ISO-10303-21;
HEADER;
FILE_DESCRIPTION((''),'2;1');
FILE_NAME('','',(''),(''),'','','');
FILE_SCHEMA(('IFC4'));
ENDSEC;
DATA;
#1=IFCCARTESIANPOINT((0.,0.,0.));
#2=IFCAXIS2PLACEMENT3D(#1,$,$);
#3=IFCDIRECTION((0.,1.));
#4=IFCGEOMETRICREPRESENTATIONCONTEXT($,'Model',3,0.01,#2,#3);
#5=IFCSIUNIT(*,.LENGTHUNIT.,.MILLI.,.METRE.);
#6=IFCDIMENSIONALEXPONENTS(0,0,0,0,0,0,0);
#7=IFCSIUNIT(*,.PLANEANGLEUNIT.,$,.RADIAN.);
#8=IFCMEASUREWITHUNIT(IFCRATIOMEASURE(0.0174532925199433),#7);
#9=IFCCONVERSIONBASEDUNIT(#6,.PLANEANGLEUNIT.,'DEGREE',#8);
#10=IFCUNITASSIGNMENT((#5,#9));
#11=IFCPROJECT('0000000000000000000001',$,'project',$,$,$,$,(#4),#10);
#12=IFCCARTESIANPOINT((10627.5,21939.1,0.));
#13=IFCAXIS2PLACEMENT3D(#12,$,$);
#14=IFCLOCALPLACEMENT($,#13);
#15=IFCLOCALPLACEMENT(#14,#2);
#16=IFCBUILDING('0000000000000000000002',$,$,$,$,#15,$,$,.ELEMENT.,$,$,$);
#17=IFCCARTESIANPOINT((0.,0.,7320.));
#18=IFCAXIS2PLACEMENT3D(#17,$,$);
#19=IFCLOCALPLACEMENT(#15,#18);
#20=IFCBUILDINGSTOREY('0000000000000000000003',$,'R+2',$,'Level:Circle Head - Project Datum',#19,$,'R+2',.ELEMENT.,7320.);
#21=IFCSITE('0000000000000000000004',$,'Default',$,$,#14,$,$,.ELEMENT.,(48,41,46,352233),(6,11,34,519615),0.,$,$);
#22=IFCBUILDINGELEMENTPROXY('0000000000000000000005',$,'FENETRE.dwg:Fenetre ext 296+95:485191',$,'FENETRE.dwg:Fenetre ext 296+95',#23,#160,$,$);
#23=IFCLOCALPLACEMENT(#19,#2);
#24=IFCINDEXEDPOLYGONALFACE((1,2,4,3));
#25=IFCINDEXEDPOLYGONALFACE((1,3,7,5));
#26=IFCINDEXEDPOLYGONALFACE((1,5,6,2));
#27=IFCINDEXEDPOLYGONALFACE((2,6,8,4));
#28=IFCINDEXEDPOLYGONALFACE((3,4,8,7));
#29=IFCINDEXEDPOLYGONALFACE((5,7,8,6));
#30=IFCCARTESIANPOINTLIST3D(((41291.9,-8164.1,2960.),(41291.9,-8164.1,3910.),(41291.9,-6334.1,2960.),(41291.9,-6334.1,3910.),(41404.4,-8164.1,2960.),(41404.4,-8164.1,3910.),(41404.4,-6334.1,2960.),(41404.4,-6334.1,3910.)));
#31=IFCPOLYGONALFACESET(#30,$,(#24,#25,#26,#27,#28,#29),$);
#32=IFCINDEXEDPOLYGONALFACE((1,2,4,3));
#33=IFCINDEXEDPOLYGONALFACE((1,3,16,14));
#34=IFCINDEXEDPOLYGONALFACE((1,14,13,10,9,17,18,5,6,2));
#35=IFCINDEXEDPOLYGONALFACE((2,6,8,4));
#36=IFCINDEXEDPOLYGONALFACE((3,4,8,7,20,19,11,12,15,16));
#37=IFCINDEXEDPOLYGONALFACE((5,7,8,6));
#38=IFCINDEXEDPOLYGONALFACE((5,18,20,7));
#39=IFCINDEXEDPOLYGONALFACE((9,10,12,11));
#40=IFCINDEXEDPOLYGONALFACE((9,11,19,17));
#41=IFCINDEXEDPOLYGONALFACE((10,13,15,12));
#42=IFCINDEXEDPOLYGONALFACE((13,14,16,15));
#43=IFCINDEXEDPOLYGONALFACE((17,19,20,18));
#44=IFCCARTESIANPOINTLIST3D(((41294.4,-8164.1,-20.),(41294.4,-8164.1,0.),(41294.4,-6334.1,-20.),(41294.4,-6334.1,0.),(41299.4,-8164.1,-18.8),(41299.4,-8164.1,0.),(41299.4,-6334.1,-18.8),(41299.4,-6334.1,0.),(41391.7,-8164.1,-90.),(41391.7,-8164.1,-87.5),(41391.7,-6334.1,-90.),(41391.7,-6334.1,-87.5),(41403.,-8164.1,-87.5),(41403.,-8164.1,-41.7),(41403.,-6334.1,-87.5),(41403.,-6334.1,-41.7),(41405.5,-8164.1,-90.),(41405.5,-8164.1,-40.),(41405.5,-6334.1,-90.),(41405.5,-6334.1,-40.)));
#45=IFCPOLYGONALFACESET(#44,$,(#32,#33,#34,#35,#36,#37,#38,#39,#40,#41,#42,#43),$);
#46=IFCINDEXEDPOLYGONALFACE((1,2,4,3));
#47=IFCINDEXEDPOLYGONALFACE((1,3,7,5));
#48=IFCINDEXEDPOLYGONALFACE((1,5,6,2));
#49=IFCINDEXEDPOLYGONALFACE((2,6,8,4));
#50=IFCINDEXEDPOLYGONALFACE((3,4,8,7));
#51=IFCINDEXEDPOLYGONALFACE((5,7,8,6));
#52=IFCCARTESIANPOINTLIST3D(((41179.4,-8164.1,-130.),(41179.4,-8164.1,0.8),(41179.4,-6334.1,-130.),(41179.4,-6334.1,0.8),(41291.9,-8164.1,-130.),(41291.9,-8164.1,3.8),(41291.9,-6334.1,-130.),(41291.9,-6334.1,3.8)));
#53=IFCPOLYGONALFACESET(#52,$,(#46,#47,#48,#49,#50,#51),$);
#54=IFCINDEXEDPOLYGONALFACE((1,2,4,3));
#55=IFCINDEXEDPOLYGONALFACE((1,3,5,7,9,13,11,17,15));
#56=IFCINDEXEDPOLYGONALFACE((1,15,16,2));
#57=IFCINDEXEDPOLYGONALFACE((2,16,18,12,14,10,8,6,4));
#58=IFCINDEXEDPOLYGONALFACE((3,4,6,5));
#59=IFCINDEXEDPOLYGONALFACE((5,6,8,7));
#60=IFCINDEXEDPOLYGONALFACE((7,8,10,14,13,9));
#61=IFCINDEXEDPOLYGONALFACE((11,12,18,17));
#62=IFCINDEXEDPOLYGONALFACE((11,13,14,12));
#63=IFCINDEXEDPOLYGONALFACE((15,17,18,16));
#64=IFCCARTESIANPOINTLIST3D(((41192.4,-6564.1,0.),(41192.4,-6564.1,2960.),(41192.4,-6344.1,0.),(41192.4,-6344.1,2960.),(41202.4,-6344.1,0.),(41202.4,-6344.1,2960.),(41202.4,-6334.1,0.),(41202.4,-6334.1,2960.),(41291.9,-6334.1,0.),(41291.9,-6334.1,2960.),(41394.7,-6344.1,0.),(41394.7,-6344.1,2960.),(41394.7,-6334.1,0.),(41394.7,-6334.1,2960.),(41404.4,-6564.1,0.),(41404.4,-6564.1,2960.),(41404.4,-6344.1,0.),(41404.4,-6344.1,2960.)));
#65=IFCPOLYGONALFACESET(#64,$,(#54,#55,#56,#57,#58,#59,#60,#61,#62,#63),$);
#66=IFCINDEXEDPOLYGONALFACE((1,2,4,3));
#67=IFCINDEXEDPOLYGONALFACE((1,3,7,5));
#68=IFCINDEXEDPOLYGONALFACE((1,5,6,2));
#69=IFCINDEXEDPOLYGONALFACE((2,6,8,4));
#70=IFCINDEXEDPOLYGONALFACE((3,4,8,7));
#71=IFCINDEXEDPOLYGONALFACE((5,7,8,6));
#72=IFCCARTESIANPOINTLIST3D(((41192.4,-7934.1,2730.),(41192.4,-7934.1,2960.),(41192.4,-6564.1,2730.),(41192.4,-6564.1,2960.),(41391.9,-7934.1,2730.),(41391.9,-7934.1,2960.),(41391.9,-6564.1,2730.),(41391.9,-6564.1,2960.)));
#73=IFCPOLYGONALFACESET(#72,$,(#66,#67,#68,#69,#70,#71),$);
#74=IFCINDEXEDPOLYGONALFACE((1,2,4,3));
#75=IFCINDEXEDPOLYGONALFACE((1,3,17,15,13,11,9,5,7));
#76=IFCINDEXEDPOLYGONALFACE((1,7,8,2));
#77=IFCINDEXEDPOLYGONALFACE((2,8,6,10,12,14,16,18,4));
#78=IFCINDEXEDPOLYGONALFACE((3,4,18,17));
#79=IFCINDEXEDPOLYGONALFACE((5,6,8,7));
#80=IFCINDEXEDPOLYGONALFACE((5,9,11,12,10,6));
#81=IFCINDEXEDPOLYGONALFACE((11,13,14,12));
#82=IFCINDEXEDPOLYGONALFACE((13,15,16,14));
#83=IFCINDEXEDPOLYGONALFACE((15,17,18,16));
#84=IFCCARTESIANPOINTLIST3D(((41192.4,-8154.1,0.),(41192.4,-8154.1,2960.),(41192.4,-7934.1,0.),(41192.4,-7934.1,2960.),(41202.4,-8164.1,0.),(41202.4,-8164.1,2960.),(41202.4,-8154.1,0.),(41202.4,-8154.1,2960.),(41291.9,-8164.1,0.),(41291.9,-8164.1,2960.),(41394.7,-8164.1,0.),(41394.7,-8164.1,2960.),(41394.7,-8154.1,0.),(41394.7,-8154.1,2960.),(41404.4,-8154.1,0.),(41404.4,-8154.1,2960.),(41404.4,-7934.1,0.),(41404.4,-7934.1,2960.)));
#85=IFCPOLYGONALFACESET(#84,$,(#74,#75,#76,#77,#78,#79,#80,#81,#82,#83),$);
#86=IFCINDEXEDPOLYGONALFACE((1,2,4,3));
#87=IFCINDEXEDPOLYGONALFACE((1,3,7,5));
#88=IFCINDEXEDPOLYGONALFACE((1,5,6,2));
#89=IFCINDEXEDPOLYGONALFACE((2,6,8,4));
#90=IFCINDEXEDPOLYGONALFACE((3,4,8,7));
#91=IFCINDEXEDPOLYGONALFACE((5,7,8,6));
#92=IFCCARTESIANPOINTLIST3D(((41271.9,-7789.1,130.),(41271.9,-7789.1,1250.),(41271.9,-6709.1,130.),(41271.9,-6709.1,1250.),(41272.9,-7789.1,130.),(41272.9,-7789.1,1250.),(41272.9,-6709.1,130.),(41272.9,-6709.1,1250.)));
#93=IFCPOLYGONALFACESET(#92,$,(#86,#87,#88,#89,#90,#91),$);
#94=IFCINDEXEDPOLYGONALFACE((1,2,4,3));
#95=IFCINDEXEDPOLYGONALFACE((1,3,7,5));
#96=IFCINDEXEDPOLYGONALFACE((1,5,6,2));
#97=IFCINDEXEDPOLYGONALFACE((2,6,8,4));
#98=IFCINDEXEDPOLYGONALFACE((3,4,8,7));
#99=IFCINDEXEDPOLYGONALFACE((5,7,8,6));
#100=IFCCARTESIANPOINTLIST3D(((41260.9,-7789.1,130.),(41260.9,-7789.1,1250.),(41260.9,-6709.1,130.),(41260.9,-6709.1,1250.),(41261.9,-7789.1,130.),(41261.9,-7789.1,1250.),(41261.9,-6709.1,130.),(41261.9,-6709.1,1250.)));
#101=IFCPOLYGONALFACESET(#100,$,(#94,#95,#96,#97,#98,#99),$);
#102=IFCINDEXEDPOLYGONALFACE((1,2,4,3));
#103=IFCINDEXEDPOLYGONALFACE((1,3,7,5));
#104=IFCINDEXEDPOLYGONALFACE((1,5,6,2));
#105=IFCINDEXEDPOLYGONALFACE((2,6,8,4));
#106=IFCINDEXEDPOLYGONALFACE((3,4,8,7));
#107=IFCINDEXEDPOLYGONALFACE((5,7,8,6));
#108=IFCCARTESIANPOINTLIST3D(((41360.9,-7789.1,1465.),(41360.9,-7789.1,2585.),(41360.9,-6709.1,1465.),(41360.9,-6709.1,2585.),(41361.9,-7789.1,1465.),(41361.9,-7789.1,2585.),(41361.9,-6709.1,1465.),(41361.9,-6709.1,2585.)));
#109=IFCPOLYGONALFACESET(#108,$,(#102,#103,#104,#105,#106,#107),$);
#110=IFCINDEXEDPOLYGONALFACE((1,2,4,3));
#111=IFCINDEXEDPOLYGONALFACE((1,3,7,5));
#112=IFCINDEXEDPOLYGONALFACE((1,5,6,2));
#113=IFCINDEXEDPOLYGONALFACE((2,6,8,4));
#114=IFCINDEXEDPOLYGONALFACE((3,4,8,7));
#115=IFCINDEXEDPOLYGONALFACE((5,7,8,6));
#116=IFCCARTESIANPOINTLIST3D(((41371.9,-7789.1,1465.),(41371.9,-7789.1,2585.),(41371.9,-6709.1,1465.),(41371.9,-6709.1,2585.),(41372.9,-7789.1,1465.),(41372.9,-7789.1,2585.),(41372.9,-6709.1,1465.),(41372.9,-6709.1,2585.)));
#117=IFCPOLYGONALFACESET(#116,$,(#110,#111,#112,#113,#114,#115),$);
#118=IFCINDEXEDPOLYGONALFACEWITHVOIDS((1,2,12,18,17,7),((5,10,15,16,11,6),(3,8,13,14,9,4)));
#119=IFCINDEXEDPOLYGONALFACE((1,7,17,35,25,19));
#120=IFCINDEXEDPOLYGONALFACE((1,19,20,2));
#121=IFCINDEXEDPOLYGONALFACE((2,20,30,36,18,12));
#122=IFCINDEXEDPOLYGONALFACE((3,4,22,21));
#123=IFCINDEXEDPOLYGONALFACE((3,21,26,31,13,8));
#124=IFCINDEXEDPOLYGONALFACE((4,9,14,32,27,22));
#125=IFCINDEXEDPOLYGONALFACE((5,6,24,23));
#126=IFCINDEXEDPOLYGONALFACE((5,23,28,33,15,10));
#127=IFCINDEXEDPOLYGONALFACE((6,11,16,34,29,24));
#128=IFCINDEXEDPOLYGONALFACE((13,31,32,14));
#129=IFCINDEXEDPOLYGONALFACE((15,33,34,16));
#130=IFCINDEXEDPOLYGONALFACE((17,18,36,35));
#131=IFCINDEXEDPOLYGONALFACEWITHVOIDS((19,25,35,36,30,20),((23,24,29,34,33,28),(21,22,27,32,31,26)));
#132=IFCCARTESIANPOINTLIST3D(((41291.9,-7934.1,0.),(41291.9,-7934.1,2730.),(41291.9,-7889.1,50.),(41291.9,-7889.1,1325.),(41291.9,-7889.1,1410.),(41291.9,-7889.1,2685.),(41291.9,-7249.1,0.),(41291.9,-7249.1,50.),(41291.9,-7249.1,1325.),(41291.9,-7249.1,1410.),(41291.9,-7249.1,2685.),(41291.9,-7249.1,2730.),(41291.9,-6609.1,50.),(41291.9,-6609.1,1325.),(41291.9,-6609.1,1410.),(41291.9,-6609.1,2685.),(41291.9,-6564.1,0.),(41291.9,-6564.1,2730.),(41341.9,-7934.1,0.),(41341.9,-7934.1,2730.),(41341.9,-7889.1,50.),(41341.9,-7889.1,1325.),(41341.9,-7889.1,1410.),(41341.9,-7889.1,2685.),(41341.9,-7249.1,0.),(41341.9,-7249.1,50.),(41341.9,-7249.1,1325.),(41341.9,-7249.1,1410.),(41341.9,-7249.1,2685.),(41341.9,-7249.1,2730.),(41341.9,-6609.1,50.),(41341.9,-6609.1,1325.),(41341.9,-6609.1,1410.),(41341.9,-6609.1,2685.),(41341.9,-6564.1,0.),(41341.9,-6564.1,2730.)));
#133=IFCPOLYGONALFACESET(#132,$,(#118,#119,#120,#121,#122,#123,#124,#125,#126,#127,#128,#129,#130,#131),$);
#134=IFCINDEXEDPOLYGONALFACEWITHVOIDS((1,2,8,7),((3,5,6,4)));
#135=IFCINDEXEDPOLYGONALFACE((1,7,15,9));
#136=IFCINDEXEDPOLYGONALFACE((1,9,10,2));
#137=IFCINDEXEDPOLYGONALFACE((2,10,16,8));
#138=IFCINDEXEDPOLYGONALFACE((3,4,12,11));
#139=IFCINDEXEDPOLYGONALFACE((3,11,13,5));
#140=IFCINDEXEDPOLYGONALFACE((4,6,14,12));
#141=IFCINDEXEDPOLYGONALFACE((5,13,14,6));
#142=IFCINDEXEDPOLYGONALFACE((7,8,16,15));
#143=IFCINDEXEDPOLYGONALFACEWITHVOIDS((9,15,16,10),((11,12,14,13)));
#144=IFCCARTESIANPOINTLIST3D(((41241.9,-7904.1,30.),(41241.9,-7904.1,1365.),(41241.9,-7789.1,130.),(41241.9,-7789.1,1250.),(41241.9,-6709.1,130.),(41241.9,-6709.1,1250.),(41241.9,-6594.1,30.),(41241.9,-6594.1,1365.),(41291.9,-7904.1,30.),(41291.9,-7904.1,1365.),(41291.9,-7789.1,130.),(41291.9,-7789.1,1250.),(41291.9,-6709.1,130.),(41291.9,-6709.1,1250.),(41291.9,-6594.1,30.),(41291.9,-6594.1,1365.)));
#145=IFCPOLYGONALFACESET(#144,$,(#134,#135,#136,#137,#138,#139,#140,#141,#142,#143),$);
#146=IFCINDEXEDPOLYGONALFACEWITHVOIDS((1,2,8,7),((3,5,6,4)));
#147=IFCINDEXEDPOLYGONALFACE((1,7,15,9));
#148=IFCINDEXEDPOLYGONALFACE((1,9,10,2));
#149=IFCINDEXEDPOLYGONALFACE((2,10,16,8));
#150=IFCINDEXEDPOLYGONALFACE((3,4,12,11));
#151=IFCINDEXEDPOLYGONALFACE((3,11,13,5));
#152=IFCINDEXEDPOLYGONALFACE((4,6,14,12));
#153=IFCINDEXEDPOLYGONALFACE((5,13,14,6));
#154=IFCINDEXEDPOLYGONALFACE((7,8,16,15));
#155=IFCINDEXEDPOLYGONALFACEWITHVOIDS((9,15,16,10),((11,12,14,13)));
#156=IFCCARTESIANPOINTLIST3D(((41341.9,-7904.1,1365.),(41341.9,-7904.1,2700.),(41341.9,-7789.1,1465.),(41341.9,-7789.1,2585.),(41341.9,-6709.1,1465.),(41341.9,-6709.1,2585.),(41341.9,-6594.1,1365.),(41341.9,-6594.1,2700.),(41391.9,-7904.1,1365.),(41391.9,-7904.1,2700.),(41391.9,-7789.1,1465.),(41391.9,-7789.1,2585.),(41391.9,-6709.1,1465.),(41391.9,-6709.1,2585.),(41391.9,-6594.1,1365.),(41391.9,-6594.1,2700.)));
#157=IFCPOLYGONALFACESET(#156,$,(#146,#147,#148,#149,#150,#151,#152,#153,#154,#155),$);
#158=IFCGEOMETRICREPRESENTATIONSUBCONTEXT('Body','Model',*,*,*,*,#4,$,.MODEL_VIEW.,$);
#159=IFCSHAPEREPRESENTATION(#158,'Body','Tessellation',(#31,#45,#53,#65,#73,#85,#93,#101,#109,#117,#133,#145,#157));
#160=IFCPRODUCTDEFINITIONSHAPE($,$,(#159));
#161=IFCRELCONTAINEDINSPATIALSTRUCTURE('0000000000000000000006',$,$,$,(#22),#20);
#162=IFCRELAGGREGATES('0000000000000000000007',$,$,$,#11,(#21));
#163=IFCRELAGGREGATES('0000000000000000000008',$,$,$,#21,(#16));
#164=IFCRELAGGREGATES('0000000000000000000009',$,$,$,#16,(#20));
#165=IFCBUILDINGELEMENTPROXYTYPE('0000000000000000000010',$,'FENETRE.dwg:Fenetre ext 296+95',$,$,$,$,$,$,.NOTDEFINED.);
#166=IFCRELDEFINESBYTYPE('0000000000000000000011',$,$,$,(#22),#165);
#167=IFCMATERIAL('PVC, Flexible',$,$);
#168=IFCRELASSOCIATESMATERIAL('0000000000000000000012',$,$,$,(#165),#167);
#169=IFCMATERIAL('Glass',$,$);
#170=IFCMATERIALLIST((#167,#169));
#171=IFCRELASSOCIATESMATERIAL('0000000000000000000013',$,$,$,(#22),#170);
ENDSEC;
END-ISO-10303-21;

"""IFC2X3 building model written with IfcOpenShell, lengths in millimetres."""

from ifc_helpers import new_model, entity, si_unit, converted_unit, direction, frame, frame_2d, origin, origin_2d_with_axis, place, context, subcontext, project, spatial, polyline, rectangle, outline, extrude, source, transform, mapped, material, material_list, type_object, type_shapes, element, save


model = new_model("IFC2X3")

# Units and contexts
model_context = context("Model", 3, precision=0.01, world=origin(), true_north=direction((0.0, 1.0)))
body_context = subcontext(model_context, "Body", "Model", "MODEL_VIEW")
ifc_project = project(units=[si_unit("LENGTHUNIT", "METRE", prefix="MILLI"), converted_unit("PLANEANGLEUNIT", "DEGREE", entity("IfcRatioMeasure", 0.0174532925199433), si_unit("PLANEANGLEUNIT", "RADIAN"), dimensions=[0, 0, 0, 0, 0, 0, 0])], contexts=[model_context])

# Site, building, storey
site_placement = place(None, frame((10627.5, 21939.1, 0.0)))
site = spatial("IfcSite", under=ifc_project, at=site_placement, Name="Default", CompositionType="ELEMENT", RefLatitude=(48, 41, 46, 352233), RefLongitude=(6, 11, 34, 519615), RefElevation=0.0)
building_placement = place(site_placement, origin())
building = spatial("IfcBuilding", under=site, at=building_placement, CompositionType="ELEMENT")
storey_placement = place(building_placement, frame((0.0, 0.0, 7320.0)))
storey = spatial("IfcBuildingStorey", under=building, at=storey_placement, Name="R+2", ObjectType="Level:Circle Head - Project Datum", LongName="R+2", CompositionType="ELEMENT", Elevation=7320.0)

# Building element proxy
ifc_material_1 = material(Name="PVC, Flexible")
ifc_material_2 = material(Name="Glass")
building_element_proxy_type_1 = type_object("IfcBuildingElementProxyType", Name="FENETRE.dwg:Fenetre ext 296+95", PredefinedType="NOTDEFINED", material=ifc_material_1)
shared_shape_1 = source(origin(), body_context, "Body", "SweptSolid", [
    extrude(rectangle(XDim=112.5, YDim=1830.0, at=origin_2d_with_axis()), frame((-10.4, -56.3, 2960.0), z_axis=(0.0, 0.0, 1.0), x_axis=(0.0, 1.0, 0.0)), (0.0, 0.0, 1.0), 950.0),
    extrude(outline(polyline([(27.5, -64.4), (47.5, -64.4), (47.5, -59.4), (28.8, -59.4), (7.5, 46.7), (-42.5, 46.7), (-42.5, 32.9), (-40.0, 32.9), (-40.0, 44.2), (5.8, 44.2), (27.5, -64.4)])), frame((-925.4, -66.9, -47.5), z_axis=(1.0, 0.0, 0.0), x_axis=(0.0, 0.0, 1.0)), (0.0, 0.0, 1.0), 1830.0),
    extrude(outline(polyline([(-54.5, -66.1), (58.0, -66.1), (54.5, 67.6), (-58.0, 64.6), (-54.5, -66.1)])), frame((-925.4, 56.3, -63.8), z_axis=(1.0, 0.0, 0.0), x_axis=(0.0, -0.999645, 0.02665)), (0.0, 0.0, 1.0), 1830.0),
    extrude(outline(polyline([(-97.0, -55.6), (5.9, -55.6), (95.4, -55.6), (95.4, -45.6), (105.4, -45.6), (105.4, 174.4), (-106.6, 174.4), (-106.6, -45.6), (-97.0, -45.6), (-97.0, -55.6)])), frame((849.0, -5.9, 0.0), z_axis=(0.0, 0.0, 1.0), x_axis=(0.0, 1.0, 0.0)), (0.0, 0.0, 1.0), 2960.0),
    extrude(rectangle(XDim=1370.0, YDim=199.5, at=origin_2d_with_axis()), frame((-10.4, -0.3, 2730.0), z_axis=(0.0, 0.0, 1.0), x_axis=(-1.0, 0.0, 0.0)), (0.0, 0.0, 1.0), 230.0),
    extrude(outline(polyline([(-55.6, 97.0), (-55.6, -5.9), (-55.6, -95.4), (-45.6, -95.4), (-45.6, -105.4), (174.4, -105.4), (174.4, 106.6), (-45.6, 106.6), (-45.6, 97.0), (-55.6, 97.0)])), frame((-869.9, -5.9, 0.0), z_axis=(0.0, 0.0, -1.0), x_axis=(1.0, 0.0, 0.0)), (0.0, 0.0, -1.0), 2960.0),
    extrude(rectangle(XDim=1080.0, YDim=1.0, at=origin_2d_with_axis()), frame((-10.4, 19.5, 130.0), z_axis=(0.0, 0.0, 1.0), x_axis=(-1.0, 0.0, 0.0)), (0.0, 0.0, 1.0), 1120.0),
    extrude(rectangle(XDim=1080.0, YDim=1.0, at=origin_2d_with_axis()), frame((-10.4, 30.5, 130.0), z_axis=(0.0, 0.0, 1.0), x_axis=(-1.0, 0.0, 0.0)), (0.0, 0.0, 1.0), 1120.0),
    extrude(rectangle(XDim=1080.0, YDim=1.0, at=frame_2d((0.0, 0.0), x_axis=(1.0, 0.0))), frame((-10.4, -69.5, 1465.0), z_axis=(0.0, 0.0, 1.0), x_axis=(-1.0, 0.0, 0.0)), (0.0, 0.0, 1.0), 1120.0),
    extrude(rectangle(XDim=1080.0, YDim=1.0, at=frame_2d((0.0, 0.0), x_axis=(1.0, 0.0))), frame((-10.4, -80.5, 1465.0), z_axis=(0.0, 0.0, 1.0), x_axis=(-1.0, 0.0, 0.0)), (0.0, 0.0, 1.0), 1120.0),
    extrude(outline(polyline([(-685.0, -1365.0), (0.0, -1365.0), (685.0, -1365.0), (685.0, 1365.0), (0.0, 1365.0), (-685.0, 1365.0), (-685.0, -1365.0)]), holes=[polyline([(-640.0, -1320.0), (-640.0, -45.0), (0.0, -45.0), (640.0, -45.0), (640.0, -1320.0), (0.0, -1320.0), (-640.0, -1320.0)]), polyline([(-640.0, 40.0), (-640.0, 1315.0), (0.0, 1315.0), (640.0, 1315.0), (640.0, 40.0), (0.0, 40.0), (-640.0, 40.0)])]), frame((-10.4, -50.0, 1365.0), z_axis=(0.0, 1.0, 0.0), x_axis=(1.0, 0.0, 0.0)), (0.0, 0.0, 1.0), 50.0),
    extrude(outline(polyline([(-655.0, -667.5), (655.0, -667.5), (655.0, 667.5), (-655.0, 667.5), (-655.0, -667.5)]), holes=[polyline([(-540.0, 552.5), (540.0, 552.5), (540.0, -567.5), (-540.0, -567.5), (-540.0, 552.5)])]), frame((-10.4, 0.0, 697.5), z_axis=(0.0, 1.0, 0.0), x_axis=(-1.0, 0.0, 0.0)), (0.0, 0.0, 1.0), 50.0),
    extrude(outline(polyline([(-655.0, -667.5), (655.0, -667.5), (655.0, 667.5), (-655.0, 667.5), (-655.0, -667.5)]), holes=[polyline([(-540.0, 552.5), (540.0, 552.5), (540.0, -567.5), (-540.0, -567.5), (-540.0, 552.5)])]), frame((-10.4, -100.0, 2032.5), z_axis=(0.0, 1.0, 0.0), x_axis=(-1.0, 0.0, 0.0)), (0.0, 0.0, 1.0), 50.0),
])
type_shapes(building_element_proxy_type_1, [shared_shape_1])
ifc_material_list_1 = material_list([ifc_material_1, ifc_material_2])
proxy_1_placement = place(storey_placement, frame((41291.9, -7238.7, 0.0), z_axis=(0.0, 0.0, 1.0), x_axis=(0.0, 1.0, 0.0)))
element("IfcBuildingElementProxy", 1, at=proxy_1_placement, inside=storey, type_object=building_element_proxy_type_1, material=ifc_material_list_1, Name="FENETRE.dwg:Fenetre ext 296+95:485191", ObjectType="FENETRE.dwg:Fenetre ext 296+95", context=body_context, shape_type="MappedRepresentation", body=[
    mapped(shared_shape_1, transform((0.0, 0.0, 0.0), scale=1.0)),
])

save(model, "model.ifc")
